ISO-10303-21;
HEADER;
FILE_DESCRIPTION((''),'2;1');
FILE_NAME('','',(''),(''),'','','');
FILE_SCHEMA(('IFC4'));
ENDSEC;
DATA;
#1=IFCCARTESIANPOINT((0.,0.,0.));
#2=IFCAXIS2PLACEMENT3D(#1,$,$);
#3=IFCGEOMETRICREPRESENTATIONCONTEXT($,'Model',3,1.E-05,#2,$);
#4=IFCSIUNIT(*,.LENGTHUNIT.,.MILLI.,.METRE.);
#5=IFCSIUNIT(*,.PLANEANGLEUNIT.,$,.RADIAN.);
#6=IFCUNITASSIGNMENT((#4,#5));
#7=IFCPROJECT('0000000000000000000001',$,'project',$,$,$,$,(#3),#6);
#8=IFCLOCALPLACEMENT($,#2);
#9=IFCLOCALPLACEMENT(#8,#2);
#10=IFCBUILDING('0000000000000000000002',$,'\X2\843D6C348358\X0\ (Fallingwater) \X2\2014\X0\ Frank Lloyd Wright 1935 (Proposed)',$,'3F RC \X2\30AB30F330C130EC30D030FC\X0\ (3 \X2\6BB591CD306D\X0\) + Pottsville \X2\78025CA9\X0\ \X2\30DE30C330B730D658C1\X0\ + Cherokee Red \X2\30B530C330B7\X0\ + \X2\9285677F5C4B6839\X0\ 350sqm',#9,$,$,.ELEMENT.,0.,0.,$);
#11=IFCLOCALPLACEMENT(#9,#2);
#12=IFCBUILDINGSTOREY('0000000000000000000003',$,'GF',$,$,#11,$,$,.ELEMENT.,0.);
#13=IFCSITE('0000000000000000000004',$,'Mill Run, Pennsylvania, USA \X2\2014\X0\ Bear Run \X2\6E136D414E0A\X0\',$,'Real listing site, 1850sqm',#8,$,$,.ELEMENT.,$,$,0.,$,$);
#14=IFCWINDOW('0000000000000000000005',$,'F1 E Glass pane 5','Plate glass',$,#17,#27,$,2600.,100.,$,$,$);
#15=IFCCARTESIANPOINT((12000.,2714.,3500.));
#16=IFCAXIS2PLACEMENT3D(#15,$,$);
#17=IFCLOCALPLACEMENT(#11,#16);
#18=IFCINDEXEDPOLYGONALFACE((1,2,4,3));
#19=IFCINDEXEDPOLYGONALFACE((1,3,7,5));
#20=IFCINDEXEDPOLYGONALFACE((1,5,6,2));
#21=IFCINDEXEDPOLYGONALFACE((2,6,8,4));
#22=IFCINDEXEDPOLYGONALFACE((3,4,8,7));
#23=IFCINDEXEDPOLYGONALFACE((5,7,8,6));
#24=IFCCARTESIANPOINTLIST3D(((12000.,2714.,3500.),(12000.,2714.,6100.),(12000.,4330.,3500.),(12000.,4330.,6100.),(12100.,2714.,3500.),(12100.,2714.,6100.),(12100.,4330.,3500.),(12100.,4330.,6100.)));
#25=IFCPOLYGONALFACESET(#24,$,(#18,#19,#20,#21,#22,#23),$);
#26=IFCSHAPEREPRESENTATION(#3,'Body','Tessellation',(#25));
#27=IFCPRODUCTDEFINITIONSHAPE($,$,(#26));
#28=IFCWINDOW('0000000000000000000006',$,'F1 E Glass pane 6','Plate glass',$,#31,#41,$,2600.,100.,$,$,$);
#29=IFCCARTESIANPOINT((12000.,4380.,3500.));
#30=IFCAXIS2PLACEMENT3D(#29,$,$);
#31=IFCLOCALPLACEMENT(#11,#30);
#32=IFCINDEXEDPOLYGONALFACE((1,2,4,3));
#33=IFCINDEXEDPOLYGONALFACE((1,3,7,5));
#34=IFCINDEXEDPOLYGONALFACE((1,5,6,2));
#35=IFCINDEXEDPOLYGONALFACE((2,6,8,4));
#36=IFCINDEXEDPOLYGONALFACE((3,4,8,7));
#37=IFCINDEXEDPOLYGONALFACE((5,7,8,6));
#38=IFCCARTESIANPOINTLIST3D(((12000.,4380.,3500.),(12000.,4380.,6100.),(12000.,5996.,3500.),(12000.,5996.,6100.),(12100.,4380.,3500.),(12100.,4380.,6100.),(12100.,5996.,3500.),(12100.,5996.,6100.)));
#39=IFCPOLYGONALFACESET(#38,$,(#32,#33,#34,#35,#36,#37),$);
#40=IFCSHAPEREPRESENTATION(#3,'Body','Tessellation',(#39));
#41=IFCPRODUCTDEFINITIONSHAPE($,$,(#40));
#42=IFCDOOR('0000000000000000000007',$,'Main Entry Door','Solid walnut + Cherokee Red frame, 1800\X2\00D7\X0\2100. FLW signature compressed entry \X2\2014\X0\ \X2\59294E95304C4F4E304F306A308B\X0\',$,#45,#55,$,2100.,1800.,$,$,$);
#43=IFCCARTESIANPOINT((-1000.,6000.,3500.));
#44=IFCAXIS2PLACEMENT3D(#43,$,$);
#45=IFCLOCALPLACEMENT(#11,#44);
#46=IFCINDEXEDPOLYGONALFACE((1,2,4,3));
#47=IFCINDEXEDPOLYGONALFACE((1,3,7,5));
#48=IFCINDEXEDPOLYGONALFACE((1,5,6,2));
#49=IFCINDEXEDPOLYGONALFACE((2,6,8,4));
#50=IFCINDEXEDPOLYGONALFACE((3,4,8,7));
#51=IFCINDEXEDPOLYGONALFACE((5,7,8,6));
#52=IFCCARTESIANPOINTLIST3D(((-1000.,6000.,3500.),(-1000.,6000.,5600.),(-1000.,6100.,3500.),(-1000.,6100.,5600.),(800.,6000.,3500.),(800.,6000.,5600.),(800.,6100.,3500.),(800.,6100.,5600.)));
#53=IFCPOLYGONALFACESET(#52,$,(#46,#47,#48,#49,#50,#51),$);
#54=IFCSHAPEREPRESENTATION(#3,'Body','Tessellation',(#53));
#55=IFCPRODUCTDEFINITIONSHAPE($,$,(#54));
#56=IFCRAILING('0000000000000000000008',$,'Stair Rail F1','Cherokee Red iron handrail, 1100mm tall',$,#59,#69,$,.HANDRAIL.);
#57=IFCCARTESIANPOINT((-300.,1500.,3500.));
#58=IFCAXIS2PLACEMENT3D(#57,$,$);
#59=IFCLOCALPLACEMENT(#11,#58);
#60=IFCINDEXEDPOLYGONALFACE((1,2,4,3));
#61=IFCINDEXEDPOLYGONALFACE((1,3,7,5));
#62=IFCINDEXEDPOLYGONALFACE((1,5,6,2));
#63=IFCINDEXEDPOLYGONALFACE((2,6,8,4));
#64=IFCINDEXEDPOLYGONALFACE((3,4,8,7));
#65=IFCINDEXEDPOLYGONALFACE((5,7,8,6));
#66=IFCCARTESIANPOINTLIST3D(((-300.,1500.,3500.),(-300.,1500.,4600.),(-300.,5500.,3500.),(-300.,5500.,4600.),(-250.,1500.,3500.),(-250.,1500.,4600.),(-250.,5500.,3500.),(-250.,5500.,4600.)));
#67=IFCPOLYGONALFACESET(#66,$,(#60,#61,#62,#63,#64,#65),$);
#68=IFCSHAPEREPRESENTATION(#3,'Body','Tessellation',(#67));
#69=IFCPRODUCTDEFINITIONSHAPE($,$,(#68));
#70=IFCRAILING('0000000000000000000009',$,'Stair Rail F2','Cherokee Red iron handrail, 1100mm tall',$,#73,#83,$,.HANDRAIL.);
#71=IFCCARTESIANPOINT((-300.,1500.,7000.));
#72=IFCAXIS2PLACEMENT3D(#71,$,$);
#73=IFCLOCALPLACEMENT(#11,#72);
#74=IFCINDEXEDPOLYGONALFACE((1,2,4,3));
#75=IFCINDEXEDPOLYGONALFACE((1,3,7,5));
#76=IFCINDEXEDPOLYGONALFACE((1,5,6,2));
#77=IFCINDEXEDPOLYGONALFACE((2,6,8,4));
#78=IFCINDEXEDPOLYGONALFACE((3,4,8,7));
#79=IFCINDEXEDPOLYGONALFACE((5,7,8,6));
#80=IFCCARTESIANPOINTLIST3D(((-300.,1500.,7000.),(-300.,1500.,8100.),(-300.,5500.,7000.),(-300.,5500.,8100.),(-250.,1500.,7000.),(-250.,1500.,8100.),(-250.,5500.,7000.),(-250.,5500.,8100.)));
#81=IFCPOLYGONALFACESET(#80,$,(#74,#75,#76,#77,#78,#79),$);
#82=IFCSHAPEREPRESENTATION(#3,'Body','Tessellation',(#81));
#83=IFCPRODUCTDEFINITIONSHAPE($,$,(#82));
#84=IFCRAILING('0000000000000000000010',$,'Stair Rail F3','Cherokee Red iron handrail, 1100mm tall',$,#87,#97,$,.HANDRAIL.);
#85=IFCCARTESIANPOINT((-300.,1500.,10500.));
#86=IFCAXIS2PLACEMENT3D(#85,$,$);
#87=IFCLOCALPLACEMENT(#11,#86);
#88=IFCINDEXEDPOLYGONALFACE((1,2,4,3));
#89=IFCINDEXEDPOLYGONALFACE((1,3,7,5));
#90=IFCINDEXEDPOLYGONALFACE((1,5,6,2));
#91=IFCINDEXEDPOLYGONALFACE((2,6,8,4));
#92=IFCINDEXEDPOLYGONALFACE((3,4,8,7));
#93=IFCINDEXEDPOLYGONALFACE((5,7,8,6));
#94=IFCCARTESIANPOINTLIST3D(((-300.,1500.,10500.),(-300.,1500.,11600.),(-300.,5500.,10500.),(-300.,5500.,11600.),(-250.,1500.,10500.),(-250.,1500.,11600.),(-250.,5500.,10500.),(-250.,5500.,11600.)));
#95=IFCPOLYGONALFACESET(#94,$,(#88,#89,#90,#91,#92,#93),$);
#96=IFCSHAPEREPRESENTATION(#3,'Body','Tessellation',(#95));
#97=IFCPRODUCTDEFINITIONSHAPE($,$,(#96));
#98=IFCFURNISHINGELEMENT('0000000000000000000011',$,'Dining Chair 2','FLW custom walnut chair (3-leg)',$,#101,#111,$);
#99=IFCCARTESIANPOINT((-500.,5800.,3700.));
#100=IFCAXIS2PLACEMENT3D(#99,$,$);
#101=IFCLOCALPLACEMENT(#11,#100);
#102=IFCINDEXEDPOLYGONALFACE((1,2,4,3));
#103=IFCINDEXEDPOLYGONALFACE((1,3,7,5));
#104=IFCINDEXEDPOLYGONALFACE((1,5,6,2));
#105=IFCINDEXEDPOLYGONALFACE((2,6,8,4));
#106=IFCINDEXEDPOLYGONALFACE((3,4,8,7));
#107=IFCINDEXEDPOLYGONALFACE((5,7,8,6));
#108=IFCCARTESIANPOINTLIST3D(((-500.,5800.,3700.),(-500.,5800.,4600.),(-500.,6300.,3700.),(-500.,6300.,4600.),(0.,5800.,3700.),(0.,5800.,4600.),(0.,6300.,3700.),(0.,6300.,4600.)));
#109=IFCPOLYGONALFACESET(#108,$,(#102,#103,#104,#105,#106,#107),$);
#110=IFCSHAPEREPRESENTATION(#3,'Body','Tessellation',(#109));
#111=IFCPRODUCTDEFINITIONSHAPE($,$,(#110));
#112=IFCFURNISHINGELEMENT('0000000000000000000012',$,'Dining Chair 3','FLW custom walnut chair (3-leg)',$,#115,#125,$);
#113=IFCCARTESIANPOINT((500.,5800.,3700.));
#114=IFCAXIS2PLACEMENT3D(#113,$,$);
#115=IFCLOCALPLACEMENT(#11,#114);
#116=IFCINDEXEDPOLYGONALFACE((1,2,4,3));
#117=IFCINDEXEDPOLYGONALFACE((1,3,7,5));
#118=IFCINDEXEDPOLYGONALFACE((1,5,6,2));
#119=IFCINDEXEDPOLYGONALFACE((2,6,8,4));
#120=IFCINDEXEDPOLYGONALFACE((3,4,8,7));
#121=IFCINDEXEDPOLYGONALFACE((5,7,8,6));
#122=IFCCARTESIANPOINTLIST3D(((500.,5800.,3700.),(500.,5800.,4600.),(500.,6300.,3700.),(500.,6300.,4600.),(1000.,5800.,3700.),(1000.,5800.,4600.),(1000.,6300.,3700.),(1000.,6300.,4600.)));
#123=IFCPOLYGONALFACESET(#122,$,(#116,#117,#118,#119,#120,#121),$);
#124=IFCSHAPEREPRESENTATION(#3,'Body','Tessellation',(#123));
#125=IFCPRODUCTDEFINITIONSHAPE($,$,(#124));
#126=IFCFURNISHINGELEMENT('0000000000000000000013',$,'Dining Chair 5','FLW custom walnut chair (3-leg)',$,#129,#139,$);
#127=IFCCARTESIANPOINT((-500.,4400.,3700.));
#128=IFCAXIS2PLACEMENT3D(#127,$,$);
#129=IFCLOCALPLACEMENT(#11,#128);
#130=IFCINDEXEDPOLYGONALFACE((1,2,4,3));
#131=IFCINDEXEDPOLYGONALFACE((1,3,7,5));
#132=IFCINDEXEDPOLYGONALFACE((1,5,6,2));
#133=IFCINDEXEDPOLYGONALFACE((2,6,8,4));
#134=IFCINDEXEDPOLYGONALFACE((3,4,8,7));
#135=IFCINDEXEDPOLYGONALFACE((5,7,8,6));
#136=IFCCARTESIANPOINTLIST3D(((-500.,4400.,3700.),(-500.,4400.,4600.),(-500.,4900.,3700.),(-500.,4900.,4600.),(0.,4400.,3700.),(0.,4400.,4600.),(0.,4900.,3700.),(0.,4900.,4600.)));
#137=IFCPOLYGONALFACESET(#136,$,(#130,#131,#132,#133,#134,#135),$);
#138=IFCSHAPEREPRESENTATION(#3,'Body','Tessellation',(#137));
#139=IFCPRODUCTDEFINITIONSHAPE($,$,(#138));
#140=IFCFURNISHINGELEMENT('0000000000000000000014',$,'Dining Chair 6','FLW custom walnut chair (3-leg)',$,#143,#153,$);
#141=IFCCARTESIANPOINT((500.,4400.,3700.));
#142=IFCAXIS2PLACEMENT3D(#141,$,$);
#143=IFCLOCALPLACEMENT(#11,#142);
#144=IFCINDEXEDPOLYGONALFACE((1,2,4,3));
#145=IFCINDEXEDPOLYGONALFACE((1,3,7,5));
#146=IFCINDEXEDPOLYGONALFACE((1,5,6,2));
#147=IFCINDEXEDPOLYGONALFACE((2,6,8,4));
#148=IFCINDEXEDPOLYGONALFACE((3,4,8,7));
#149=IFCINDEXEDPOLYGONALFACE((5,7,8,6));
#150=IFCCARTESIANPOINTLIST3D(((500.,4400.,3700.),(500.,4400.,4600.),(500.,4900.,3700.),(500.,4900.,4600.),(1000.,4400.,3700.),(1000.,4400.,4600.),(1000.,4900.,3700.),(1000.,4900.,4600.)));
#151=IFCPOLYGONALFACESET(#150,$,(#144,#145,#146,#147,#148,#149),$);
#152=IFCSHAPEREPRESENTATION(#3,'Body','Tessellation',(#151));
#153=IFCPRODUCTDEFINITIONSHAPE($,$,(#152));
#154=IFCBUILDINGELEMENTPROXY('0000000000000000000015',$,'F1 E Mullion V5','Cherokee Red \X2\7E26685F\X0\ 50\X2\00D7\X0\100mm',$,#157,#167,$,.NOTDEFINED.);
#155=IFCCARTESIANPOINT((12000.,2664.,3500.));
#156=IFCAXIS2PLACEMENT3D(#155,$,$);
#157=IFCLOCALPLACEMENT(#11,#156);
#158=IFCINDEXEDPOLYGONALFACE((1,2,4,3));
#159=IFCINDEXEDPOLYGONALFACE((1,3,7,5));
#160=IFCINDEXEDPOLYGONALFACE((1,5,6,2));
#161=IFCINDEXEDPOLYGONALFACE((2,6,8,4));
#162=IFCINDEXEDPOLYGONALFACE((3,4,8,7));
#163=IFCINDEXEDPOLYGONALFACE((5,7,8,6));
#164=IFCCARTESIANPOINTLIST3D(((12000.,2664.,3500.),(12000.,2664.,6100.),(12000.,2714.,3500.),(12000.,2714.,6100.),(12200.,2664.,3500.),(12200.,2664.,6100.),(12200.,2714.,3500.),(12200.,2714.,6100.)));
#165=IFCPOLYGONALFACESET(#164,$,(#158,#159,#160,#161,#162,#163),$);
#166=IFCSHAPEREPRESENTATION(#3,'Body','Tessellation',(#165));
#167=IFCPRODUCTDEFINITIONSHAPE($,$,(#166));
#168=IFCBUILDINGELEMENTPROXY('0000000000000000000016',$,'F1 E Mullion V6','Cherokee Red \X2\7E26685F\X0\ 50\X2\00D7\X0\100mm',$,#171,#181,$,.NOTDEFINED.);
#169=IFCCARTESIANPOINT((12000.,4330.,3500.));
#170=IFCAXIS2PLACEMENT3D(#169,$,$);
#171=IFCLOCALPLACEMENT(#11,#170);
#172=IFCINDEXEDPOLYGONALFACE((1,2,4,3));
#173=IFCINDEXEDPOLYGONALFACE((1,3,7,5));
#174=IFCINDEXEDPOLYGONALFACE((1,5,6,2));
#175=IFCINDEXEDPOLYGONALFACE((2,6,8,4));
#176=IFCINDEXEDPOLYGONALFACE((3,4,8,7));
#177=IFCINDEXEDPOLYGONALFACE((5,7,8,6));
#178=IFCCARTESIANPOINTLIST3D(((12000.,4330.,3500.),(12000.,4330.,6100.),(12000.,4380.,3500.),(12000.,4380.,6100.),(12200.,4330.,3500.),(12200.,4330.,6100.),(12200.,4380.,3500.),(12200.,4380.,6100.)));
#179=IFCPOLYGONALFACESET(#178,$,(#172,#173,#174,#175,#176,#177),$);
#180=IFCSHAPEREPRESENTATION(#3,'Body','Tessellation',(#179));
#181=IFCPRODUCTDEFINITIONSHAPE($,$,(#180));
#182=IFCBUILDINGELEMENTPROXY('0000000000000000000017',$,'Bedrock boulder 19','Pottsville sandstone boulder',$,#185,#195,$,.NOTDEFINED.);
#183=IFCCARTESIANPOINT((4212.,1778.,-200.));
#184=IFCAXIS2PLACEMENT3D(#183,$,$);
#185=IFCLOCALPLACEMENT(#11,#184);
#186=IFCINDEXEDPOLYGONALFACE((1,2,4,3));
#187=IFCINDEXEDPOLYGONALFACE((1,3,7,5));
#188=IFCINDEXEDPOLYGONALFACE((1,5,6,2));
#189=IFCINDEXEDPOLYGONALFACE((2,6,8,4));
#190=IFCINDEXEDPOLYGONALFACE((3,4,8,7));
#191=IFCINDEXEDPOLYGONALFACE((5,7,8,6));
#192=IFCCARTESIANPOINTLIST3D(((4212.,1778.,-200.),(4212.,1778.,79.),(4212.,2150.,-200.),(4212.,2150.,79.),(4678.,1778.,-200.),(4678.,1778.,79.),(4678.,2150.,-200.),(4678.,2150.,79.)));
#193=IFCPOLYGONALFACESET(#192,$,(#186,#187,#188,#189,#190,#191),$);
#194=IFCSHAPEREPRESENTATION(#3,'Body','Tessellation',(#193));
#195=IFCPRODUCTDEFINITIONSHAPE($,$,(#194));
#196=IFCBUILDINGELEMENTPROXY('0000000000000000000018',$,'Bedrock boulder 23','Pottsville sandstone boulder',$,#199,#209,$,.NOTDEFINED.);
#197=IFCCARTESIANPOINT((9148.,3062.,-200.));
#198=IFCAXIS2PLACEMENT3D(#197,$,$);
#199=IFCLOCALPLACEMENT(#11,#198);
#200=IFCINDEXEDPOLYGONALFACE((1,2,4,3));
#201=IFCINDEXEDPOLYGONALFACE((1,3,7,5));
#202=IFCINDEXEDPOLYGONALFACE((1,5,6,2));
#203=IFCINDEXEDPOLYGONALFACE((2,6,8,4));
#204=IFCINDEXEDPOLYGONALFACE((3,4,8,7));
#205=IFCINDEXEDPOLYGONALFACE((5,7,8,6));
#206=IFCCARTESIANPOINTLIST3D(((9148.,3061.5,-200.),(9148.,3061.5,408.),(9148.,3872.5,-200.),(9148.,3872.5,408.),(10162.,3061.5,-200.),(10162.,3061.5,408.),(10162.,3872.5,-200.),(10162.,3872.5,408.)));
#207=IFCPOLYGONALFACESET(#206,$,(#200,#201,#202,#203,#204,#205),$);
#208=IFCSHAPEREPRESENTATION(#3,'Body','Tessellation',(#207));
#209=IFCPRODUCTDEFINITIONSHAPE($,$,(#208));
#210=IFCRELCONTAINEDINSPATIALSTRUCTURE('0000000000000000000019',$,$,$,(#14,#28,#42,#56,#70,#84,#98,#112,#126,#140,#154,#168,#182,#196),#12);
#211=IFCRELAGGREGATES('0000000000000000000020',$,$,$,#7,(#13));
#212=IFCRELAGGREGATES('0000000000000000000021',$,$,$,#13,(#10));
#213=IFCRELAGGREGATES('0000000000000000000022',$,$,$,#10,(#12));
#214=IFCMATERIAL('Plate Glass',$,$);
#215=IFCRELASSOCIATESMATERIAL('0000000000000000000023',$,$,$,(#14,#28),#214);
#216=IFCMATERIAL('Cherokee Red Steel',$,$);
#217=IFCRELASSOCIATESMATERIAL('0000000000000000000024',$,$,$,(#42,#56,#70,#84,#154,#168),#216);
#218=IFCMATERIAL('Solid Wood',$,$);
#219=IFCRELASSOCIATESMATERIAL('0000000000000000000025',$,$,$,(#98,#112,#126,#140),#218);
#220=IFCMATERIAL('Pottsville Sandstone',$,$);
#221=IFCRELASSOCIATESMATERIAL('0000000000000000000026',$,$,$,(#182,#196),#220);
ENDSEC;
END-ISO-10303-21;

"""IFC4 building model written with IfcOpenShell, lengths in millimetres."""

from ifc_helpers import new_model, si_unit, frame, frame_2d, origin, place, context, project, spatial, rectangle, extrude, material, element, save


model = new_model("IFC4")

# Units and contexts
model_context = context("Model", 3, precision=1e-05, world=origin())
ifc_project = project(units=[si_unit("LENGTHUNIT", "METRE", prefix="MILLI"), si_unit("PLANEANGLEUNIT", "RADIAN")], contexts=[model_context])

# Site, building, storey
site_placement = place(None, origin())
site = spatial("IfcSite", under=ifc_project, at=site_placement, Name="Mill Run, Pennsylvania, USA — Bear Run 渓流上", ObjectType="Real listing site, 1850sqm", CompositionType="ELEMENT", RefElevation=0.0)
building_placement = place(site_placement, origin())
building = spatial("IfcBuilding", under=site, at=building_placement, Name="落水荘 (Fallingwater) — Frank Lloyd Wright 1935 (Proposed)", ObjectType="3F RC カンチレバー (3 段重ね) + Pottsville 砂岩 マッシブ壁 + Cherokee Red サッシ + 銅板屋根 350sqm", CompositionType="ELEMENT", ElevationOfRefHeight=0.0, ElevationOfTerrain=0.0)
storey_placement = place(building_placement, origin())
storey = spatial("IfcBuildingStorey", under=building, at=storey_placement, Name="GF", CompositionType="ELEMENT", Elevation=0.0)

# Windows
ifc_material_1 = material(Name="Plate Glass")
window_1_placement = place(storey_placement, frame((12000.0, 2714.0, 3500.0)))
element("IfcWindow", 1, at=window_1_placement, inside=storey, material=ifc_material_1, Name="F1 E Glass pane 5", Description="Plate glass", OverallHeight=2600.0, OverallWidth=100.0, context=model_context, shape_type="SweptSolid", body=[
    extrude(rectangle(XDim=100.0, YDim=1616.0, at=frame_2d((50.0, 808.0))), frame((12000.0, 2714.0, 3500.0)), (0.0, 0.0, 1.0), 2600.0),
])
window_2_placement = place(storey_placement, frame((12000.0, 4380.0, 3500.0)))
element("IfcWindow", 2, at=window_2_placement, inside=storey, material=ifc_material_1, Name="F1 E Glass pane 6", Description="Plate glass", OverallHeight=2600.0, OverallWidth=100.0, context=model_context, shape_type="SweptSolid", body=[
    extrude(rectangle(XDim=100.0, YDim=1616.0, at=frame_2d((50.0, 808.0))), frame((12000.0, 4380.0, 3500.0)), (0.0, 0.0, 1.0), 2600.0),
])

# Door
ifc_material_2 = material(Name="Cherokee Red Steel")
door_placement = place(storey_placement, frame((-1000.0, 6000.0, 3500.0)))
element("IfcDoor", 3, at=door_placement, inside=storey, material=ifc_material_2, Name="Main Entry Door", Description="Solid walnut + Cherokee Red frame, 1800×2100. FLW signature compressed entry — 天井が低くなる", OverallHeight=2100.0, OverallWidth=1800.0, context=model_context, shape_type="SweptSolid", body=[
    extrude(rectangle(XDim=1800.0, YDim=100.0, at=frame_2d((900.0, 50.0))), frame((-1000.0, 6000.0, 3500.0)), (0.0, 0.0, 1.0), 2100.0),
])

# Railings
railing_1_placement = place(storey_placement, frame((-300.0, 1500.0, 3500.0)))
element("IfcRailing", 4, at=railing_1_placement, inside=storey, material=ifc_material_2, Name="Stair Rail F1", Description="Cherokee Red iron handrail, 1100mm tall", PredefinedType="HANDRAIL", context=model_context, shape_type="SweptSolid", body=[
    extrude(rectangle(XDim=50.0, YDim=4000.0, at=frame_2d((25.0, 2000.0))), frame((-300.0, 1500.0, 3500.0)), (0.0, 0.0, 1.0), 1100.0),
])
railing_2_placement = place(storey_placement, frame((-300.0, 1500.0, 7000.0)))
element("IfcRailing", 5, at=railing_2_placement, inside=storey, material=ifc_material_2, Name="Stair Rail F2", Description="Cherokee Red iron handrail, 1100mm tall", PredefinedType="HANDRAIL", context=model_context, shape_type="SweptSolid", body=[
    extrude(rectangle(XDim=50.0, YDim=4000.0, at=frame_2d((25.0, 2000.0))), frame((-300.0, 1500.0, 7000.0)), (0.0, 0.0, 1.0), 1100.0),
])
railing_3_placement = place(storey_placement, frame((-300.0, 1500.0, 10500.0)))
element("IfcRailing", 6, at=railing_3_placement, inside=storey, material=ifc_material_2, Name="Stair Rail F3", Description="Cherokee Red iron handrail, 1100mm tall", PredefinedType="HANDRAIL", context=model_context, shape_type="SweptSolid", body=[
    extrude(rectangle(XDim=50.0, YDim=4000.0, at=frame_2d((25.0, 2000.0))), frame((-300.0, 1500.0, 10500.0)), (0.0, 0.0, 1.0), 1100.0),
])

# Furnishing elements
ifc_material_3 = material(Name="Solid Wood")
furnishing_1_placement = place(storey_placement, frame((-500.0, 5800.0, 3700.0)))
element("IfcFurnishingElement", 7, at=furnishing_1_placement, inside=storey, material=ifc_material_3, Name="Dining Chair 2", Description="FLW custom walnut chair (3-leg)", context=model_context, shape_type="SweptSolid", body=[
    extrude(rectangle(XDim=500.0, YDim=500.0, at=frame_2d((250.0, 250.0))), frame((-500.0, 5800.0, 3700.0)), (0.0, 0.0, 1.0), 900.0),
])
furnishing_2_placement = place(storey_placement, frame((500.0, 5800.0, 3700.0)))
element("IfcFurnishingElement", 8, at=furnishing_2_placement, inside=storey, material=ifc_material_3, Name="Dining Chair 3", Description="FLW custom walnut chair (3-leg)", context=model_context, shape_type="SweptSolid", body=[
    extrude(rectangle(XDim=500.0, YDim=500.0, at=frame_2d((250.0, 250.0))), frame((500.0, 5800.0, 3700.0)), (0.0, 0.0, 1.0), 900.0),
])
furnishing_3_placement = place(storey_placement, frame((-500.0, 4400.0, 3700.0)))
element("IfcFurnishingElement", 9, at=furnishing_3_placement, inside=storey, material=ifc_material_3, Name="Dining Chair 5", Description="FLW custom walnut chair (3-leg)", context=model_context, shape_type="SweptSolid", body=[
    extrude(rectangle(XDim=500.0, YDim=500.0, at=frame_2d((250.0, 250.0))), frame((-500.0, 4400.0, 3700.0)), (0.0, 0.0, 1.0), 900.0),
])
furnishing_4_placement = place(storey_placement, frame((500.0, 4400.0, 3700.0)))
element("IfcFurnishingElement", 10, at=furnishing_4_placement, inside=storey, material=ifc_material_3, Name="Dining Chair 6", Description="FLW custom walnut chair (3-leg)", context=model_context, shape_type="SweptSolid", body=[
    extrude(rectangle(XDim=500.0, YDim=500.0, at=frame_2d((250.0, 250.0))), frame((500.0, 4400.0, 3700.0)), (0.0, 0.0, 1.0), 900.0),
])

# Building element proxies
proxy_1_placement = place(storey_placement, frame((12000.0, 2664.0, 3500.0)))
element("IfcBuildingElementProxy", 11, at=proxy_1_placement, inside=storey, material=ifc_material_2, Name="F1 E Mullion V5", Description="Cherokee Red 縦桟 50×100mm", PredefinedType="NOTDEFINED", context=model_context, shape_type="SweptSolid", body=[
    extrude(rectangle(XDim=200.0, YDim=50.0, at=frame_2d((100.0, 25.0))), frame((12000.0, 2664.0, 3500.0)), (0.0, 0.0, 1.0), 2600.0),
])
proxy_2_placement = place(storey_placement, frame((12000.0, 4330.0, 3500.0)))
element("IfcBuildingElementProxy", 12, at=proxy_2_placement, inside=storey, material=ifc_material_2, Name="F1 E Mullion V6", Description="Cherokee Red 縦桟 50×100mm", PredefinedType="NOTDEFINED", context=model_context, shape_type="SweptSolid", body=[
    extrude(rectangle(XDim=200.0, YDim=50.0, at=frame_2d((100.0, 25.0))), frame((12000.0, 4330.0, 3500.0)), (0.0, 0.0, 1.0), 2600.0),
])
ifc_material_4 = material(Name="Pottsville Sandstone")
proxy_3_placement = place(storey_placement, frame((4212.0, 1778.0, -200.0)))
element("IfcBuildingElementProxy", 13, at=proxy_3_placement, inside=storey, material=ifc_material_4, Name="Bedrock boulder 19", Description="Pottsville sandstone boulder", PredefinedType="NOTDEFINED", context=model_context, shape_type="SweptSolid", body=[
    extrude(rectangle(XDim=466.0, YDim=372.0, at=frame_2d((233.0, 186.0))), frame((4212.0, 1778.0, -200.0)), (0.0, 0.0, 1.0), 279.0),
])
proxy_4_placement = place(storey_placement, frame((9148.0, 3062.0, -200.0)))
element("IfcBuildingElementProxy", 14, at=proxy_4_placement, inside=storey, material=ifc_material_4, Name="Bedrock boulder 23", Description="Pottsville sandstone boulder", PredefinedType="NOTDEFINED", context=model_context, shape_type="SweptSolid", body=[
    extrude(rectangle(XDim=1014.0, YDim=811.0, at=frame_2d((507.0, 405.0))), frame((9148.0, 3062.0, -200.0)), (0.0, 0.0, 1.0), 608.0),
])

save(model, "model.ifc")
